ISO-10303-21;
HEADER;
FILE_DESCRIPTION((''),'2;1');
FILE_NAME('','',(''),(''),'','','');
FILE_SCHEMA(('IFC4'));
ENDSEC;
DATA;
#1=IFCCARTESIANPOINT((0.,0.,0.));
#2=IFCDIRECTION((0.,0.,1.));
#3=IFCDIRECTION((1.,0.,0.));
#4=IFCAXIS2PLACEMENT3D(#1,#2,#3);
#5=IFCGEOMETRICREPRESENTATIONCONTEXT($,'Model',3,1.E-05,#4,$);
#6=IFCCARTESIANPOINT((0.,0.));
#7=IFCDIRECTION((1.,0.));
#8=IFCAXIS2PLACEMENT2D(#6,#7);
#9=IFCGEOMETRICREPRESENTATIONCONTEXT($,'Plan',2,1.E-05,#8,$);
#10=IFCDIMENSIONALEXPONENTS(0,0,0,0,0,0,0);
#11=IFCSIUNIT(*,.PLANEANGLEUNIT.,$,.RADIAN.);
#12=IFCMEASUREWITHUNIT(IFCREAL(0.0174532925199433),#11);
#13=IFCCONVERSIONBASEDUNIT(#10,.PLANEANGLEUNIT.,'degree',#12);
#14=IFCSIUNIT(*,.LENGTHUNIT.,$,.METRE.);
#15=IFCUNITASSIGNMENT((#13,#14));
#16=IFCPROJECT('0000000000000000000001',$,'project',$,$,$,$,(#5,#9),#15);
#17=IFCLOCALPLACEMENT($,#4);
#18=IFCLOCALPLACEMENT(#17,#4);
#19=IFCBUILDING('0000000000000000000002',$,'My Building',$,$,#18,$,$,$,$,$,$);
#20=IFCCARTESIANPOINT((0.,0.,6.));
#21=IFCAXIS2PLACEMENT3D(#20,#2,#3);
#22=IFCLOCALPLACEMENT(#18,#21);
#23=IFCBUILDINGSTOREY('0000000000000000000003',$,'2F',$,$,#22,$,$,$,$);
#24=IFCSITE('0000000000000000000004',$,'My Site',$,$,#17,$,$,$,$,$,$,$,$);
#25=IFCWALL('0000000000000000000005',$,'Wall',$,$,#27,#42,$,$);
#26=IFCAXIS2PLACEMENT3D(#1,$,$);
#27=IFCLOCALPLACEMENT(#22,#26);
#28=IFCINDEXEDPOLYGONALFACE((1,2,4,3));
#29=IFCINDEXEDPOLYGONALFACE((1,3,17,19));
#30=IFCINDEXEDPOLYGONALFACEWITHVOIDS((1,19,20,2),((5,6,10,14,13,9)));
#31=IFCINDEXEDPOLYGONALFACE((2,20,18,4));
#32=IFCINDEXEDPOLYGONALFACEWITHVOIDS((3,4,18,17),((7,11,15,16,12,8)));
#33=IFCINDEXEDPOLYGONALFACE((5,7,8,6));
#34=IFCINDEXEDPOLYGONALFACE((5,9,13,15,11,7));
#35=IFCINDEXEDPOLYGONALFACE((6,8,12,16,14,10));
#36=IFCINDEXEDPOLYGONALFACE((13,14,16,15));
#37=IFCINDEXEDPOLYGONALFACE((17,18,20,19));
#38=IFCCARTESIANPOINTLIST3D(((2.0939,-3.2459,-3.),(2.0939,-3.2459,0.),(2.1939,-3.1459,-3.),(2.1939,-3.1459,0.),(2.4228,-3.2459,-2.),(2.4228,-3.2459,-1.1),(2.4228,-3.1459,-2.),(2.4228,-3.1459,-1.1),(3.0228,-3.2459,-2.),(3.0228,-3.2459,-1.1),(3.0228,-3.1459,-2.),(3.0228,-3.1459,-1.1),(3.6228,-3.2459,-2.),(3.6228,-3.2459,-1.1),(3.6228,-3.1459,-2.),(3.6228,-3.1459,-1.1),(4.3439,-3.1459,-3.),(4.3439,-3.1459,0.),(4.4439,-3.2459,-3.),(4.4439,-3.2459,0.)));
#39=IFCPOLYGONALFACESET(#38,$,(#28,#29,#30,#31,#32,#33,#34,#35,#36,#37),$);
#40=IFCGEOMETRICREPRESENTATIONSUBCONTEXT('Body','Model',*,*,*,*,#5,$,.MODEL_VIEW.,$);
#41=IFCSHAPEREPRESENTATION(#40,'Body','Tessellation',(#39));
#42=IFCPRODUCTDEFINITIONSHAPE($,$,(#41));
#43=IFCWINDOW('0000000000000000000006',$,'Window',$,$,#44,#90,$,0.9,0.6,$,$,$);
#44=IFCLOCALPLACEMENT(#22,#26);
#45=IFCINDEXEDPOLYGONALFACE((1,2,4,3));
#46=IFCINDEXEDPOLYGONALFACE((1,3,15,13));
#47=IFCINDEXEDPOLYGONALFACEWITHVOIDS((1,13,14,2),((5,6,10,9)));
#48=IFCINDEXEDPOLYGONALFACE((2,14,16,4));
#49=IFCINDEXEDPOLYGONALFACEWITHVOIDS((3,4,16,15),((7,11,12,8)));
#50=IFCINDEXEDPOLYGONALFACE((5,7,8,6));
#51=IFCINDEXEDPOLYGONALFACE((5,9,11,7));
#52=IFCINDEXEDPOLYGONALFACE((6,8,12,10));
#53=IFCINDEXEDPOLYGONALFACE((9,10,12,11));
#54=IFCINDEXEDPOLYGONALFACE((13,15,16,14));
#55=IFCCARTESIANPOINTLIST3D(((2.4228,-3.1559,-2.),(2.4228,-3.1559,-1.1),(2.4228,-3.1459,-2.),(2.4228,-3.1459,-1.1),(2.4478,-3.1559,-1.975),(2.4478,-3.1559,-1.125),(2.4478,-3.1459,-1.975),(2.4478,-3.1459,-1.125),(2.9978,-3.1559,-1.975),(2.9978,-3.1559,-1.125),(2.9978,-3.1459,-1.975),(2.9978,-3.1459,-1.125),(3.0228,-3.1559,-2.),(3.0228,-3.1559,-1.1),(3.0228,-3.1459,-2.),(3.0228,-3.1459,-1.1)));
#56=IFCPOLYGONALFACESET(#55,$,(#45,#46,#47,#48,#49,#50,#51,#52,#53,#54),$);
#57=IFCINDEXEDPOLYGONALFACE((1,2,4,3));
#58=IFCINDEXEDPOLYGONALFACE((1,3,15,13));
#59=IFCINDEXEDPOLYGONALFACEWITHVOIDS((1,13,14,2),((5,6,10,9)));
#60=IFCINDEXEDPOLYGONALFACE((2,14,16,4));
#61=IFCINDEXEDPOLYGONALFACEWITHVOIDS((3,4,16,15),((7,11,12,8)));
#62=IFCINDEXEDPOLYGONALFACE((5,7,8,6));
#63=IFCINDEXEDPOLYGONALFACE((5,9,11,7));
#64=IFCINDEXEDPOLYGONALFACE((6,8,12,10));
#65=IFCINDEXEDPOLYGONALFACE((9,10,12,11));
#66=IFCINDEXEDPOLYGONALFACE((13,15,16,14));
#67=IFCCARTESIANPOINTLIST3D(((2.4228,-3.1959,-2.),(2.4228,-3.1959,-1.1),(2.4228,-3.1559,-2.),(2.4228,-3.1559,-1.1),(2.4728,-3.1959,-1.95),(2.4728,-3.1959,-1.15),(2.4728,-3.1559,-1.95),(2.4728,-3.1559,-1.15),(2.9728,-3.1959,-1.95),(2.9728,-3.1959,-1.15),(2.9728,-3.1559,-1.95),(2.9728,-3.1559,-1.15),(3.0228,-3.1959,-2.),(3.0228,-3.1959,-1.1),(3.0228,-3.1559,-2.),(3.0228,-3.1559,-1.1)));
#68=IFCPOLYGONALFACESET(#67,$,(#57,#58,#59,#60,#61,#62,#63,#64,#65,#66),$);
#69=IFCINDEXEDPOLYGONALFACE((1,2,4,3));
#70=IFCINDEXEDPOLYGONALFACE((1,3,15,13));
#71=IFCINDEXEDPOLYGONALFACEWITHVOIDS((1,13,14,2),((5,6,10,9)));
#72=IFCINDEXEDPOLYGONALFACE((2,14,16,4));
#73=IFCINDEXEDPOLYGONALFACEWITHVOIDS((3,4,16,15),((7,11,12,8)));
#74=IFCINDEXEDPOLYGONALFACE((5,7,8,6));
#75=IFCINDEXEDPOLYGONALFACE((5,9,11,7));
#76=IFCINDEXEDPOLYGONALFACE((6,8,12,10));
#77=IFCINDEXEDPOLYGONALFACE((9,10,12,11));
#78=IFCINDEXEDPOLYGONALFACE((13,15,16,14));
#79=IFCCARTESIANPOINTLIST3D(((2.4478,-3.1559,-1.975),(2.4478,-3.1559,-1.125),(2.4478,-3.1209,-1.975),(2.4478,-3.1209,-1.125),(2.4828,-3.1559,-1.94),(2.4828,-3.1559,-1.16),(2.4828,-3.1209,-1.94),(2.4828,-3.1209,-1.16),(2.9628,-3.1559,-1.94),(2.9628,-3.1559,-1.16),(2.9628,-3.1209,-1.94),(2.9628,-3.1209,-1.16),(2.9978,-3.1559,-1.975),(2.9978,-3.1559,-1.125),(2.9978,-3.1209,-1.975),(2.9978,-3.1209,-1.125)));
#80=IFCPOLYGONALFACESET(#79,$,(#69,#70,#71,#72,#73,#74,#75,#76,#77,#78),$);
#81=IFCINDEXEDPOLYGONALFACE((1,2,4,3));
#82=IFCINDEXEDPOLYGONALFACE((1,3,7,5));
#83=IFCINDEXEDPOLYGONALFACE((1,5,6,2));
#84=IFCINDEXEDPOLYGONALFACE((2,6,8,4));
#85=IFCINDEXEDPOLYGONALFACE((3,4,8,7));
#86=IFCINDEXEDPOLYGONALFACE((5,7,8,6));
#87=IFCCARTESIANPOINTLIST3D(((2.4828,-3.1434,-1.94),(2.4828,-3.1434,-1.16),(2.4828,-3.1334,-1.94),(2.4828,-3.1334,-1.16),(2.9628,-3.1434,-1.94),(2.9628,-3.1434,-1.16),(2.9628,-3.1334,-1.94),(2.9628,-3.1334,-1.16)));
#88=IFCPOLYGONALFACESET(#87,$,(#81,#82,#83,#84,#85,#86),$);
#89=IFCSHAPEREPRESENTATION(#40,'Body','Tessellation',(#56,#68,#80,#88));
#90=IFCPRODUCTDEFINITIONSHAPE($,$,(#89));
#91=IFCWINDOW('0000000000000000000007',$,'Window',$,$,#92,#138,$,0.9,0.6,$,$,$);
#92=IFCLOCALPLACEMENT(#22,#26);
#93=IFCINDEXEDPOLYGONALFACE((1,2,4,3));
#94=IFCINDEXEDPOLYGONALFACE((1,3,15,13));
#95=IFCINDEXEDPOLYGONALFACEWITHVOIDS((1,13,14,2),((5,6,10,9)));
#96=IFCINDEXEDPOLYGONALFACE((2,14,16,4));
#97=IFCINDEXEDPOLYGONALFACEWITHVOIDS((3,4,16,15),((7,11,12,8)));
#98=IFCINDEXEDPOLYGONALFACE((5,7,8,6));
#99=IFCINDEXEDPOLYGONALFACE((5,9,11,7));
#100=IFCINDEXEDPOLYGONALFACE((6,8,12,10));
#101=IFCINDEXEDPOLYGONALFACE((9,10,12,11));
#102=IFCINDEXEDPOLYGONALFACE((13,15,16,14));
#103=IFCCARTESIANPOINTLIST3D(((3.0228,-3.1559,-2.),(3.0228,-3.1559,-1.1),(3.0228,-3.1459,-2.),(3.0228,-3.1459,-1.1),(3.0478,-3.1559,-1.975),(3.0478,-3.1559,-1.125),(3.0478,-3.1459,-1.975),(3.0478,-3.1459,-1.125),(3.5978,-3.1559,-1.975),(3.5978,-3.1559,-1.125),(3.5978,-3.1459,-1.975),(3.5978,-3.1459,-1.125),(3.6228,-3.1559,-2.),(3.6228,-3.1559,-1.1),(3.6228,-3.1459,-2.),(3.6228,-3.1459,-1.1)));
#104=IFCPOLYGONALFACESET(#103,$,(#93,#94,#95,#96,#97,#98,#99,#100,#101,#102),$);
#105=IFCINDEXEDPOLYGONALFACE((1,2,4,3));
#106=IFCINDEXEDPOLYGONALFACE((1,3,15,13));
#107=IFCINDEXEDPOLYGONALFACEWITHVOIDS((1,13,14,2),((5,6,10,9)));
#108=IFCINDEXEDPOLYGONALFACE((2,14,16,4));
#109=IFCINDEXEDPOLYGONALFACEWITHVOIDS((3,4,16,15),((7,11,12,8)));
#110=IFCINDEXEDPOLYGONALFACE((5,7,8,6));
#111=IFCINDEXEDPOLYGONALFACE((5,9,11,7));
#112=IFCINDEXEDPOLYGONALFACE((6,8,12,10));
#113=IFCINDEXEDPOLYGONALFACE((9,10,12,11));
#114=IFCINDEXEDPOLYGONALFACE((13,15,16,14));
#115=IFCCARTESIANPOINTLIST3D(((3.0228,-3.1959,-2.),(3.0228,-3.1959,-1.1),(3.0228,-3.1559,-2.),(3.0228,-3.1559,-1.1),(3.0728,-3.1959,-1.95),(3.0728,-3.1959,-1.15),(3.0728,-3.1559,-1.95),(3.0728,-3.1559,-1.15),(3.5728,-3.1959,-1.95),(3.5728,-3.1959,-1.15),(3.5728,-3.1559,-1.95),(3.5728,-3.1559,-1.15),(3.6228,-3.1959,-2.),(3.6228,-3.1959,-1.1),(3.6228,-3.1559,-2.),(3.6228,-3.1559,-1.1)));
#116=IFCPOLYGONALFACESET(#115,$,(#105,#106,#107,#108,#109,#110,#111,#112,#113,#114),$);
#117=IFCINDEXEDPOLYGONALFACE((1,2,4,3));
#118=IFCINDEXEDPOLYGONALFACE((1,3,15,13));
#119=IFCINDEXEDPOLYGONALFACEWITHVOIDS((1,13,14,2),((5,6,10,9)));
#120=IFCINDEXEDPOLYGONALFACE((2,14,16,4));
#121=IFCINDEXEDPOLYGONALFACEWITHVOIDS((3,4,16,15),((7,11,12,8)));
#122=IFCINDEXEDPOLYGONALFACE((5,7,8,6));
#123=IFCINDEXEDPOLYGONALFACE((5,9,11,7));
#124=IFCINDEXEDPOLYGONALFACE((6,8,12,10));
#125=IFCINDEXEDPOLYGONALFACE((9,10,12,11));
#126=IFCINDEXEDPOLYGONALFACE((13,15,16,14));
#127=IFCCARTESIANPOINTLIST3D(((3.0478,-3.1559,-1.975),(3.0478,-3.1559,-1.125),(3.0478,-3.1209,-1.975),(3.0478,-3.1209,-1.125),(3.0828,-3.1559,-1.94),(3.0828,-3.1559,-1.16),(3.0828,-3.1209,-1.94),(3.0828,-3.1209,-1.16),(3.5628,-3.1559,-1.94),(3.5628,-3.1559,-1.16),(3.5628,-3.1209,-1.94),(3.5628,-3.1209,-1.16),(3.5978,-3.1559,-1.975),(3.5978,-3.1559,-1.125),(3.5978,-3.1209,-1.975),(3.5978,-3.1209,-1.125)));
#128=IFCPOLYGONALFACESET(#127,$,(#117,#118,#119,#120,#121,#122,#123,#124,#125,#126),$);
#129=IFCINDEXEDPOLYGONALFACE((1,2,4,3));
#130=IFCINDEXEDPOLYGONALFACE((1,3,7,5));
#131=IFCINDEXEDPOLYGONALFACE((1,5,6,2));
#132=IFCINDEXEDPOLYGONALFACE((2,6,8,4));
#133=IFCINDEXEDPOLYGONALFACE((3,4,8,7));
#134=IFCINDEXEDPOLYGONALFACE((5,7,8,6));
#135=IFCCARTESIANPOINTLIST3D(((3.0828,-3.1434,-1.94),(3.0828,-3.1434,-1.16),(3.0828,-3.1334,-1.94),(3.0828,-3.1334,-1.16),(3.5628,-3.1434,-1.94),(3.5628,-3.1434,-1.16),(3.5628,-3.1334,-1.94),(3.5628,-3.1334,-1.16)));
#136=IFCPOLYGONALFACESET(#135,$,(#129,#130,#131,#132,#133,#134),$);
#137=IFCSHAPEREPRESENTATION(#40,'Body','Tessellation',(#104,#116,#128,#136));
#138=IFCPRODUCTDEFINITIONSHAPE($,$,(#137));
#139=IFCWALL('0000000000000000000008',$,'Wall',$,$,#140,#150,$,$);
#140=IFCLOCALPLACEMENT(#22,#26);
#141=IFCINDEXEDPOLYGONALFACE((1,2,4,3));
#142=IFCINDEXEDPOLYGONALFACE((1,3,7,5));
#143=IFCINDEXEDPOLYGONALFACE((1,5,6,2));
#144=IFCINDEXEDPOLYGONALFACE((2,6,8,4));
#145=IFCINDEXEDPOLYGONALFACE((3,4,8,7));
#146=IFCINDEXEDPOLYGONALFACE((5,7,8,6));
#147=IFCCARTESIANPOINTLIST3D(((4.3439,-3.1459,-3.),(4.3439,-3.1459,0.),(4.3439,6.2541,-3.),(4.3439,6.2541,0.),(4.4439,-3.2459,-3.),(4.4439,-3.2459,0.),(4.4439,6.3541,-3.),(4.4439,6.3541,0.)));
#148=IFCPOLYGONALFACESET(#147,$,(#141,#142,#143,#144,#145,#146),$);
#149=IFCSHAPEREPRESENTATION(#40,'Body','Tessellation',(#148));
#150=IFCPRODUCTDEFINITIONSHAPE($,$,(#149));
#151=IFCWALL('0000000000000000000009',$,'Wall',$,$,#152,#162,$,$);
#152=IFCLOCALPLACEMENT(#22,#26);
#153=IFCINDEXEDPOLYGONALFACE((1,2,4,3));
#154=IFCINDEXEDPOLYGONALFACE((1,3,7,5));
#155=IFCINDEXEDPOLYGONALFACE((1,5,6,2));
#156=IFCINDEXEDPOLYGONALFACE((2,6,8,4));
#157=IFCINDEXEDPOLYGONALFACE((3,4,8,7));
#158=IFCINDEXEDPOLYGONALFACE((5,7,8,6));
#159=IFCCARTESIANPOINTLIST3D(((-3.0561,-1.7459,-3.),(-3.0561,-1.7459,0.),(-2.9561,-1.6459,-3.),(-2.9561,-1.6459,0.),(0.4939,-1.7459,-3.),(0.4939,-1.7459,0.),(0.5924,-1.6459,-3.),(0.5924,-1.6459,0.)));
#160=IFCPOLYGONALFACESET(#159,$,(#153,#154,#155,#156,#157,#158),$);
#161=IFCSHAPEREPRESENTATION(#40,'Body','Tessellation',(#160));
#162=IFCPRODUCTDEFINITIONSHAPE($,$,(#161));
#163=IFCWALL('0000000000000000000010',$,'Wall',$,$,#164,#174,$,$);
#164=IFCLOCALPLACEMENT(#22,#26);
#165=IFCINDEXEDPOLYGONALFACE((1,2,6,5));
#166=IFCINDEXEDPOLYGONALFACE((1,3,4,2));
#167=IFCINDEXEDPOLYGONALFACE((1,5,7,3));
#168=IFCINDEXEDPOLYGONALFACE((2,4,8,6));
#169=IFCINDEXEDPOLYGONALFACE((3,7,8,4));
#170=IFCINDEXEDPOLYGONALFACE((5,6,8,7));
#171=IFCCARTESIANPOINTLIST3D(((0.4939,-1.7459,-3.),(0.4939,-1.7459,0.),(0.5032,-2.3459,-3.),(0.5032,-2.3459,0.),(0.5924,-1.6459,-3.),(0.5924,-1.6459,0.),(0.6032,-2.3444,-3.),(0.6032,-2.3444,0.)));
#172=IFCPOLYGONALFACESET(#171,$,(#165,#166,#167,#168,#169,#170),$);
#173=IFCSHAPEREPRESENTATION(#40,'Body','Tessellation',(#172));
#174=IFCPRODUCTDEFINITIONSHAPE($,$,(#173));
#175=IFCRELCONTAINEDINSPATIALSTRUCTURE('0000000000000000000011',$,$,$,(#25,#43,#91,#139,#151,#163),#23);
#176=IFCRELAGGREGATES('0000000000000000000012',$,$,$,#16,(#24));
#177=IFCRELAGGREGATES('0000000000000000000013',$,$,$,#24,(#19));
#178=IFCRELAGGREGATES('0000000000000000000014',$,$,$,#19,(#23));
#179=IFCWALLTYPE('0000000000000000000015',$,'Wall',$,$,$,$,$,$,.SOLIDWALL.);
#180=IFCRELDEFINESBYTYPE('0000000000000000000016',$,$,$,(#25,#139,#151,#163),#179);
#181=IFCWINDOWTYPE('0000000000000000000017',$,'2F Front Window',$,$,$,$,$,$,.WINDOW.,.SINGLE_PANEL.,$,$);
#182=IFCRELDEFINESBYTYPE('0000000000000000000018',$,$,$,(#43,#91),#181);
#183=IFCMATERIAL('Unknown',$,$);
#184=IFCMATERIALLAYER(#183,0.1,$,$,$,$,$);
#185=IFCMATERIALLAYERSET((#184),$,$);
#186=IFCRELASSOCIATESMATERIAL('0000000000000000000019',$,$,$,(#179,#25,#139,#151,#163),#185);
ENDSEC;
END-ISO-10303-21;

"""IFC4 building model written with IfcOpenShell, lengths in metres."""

from ifc_helpers import new_model, entity, si_unit, converted_unit, frame, origin_with_axes, origin_2d_with_axis, place, context, subcontext, project, spatial, line, indexed_curve, outline, extrude, shape, source, transform, mapped, material, layer, layer_set, layer_usage, type_object, type_shapes, element, fill, save


model = new_model("IFC4")

# Units and contexts
model_context = context("Model", 3, precision=1e-05, world=origin_with_axes())
plan_context = context("Plan", 2, precision=1e-05, world=origin_2d_with_axis())
body_context_1 = subcontext(model_context, "Body", "Model", "MODEL_VIEW")
body_context_2 = subcontext(plan_context, "Body", "Plan", "PLAN_VIEW")
ifc_project = project(units=[converted_unit("PLANEANGLEUNIT", "degree", entity("IfcReal", 0.0174532925199433), si_unit("PLANEANGLEUNIT", "RADIAN"), dimensions=[0, 0, 0, 0, 0, 0, 0]), si_unit("LENGTHUNIT", "METRE")], contexts=[model_context, plan_context])

# Site, building, storey
site_placement = place(None, origin_with_axes())
site = spatial("IfcSite", under=ifc_project, at=site_placement, Name="My Site")
building_placement = place(site_placement, origin_with_axes())
building = spatial("IfcBuilding", under=site, at=building_placement, Name="My Building")
storey_placement = place(building_placement, frame((0.0, 0.0, 6.0), z_axis=(0.0, 0.0, 1.0), x_axis=(1.0, 0.0, 0.0)))
storey = spatial("IfcBuildingStorey", under=building, at=storey_placement, Name="2F")

# Shared definitions
ifc_material = material(Name="Unknown")

# Shared definitions
ifc_layer_1 = layer(ifc_material, 0.1)
ifc_layer_set_1 = layer_set([ifc_layer_1])
wall_type = type_object("IfcWallType", Name="Wall", PredefinedType="SOLIDWALL", material=ifc_layer_set_1)

# Wall, openings, windows
ifc_layer_usage_1 = layer_usage(ifc_layer_set_1, "AXIS2", "POSITIVE", 0.0)
wall_1_placement = place(storey_placement, frame((2.0939, -3.2459, -3.0), z_axis=(0.0, 0.0, 1.0), x_axis=(1.0, 0.0, 0.0)))
wall_1 = element("IfcWall", 1, at=wall_1_placement, inside=storey, type_object=wall_type, material=ifc_layer_usage_1, Name="Wall", context=body_context_1, shape_type="SweptSolid", body=[
    extrude(outline(indexed_curve([(0.0, 0.0), (0.1, 0.1), (2.25, 0.1), (2.35, 0.0)], segments=[line(1, 2, 3, 4, 1)])), origin_with_axes(), (0.0, 0.0, 1.0), 3.0),
])
shared_shape_1 = source(origin_with_axes(), body_context_1, "Body", "SweptSolid", [
    extrude(outline(indexed_curve([(0.0, 0.0), (0.6, 0.0), (0.6, 0.9), (0.0, 0.9)], segments=[line(1, 2, 3, 4, 1)])), frame((0.0, -0.6, 0.0), z_axis=(0.0, -1.0, 0.0), x_axis=(1.0, 0.0, 0.0)), (0.0, 0.0, -1.0), 1.2),
])
opening_1_placement = place(wall_1_placement, frame((0.3289, 0.0, 1.0), z_axis=(0.0, 0.0, 1.0), x_axis=(1.0, 0.0, 0.0)))
opening_1 = element("IfcOpeningElement", 2, at=opening_1_placement, cuts=wall_1, PredefinedType="OPENING", context=body_context_1, shape_type="MappedRepresentation", body=[
    mapped(shared_shape_1, transform((0.0, 0.0, 0.0), x_axis=(1.0, 0.0, 0.0), y_axis=(0.0, 1.0, 0.0), z_axis=(0.0, 0.0, 1.0), scale=1.0)),
])
opening_2_placement = place(wall_1_placement, frame((0.9289, 0.0, 1.0), z_axis=(0.0, 0.0, 1.0), x_axis=(1.0, 0.0, 0.0)))
opening_2 = element("IfcOpeningElement", 3, at=opening_2_placement, cuts=wall_1, PredefinedType="OPENING", context=body_context_1, shape_type="MappedRepresentation", body=[
    mapped(shared_shape_1, transform((0.0, 0.0, 0.0), x_axis=(1.0, 0.0, 0.0), y_axis=(0.0, 1.0, 0.0), z_axis=(0.0, 0.0, 1.0), scale=1.0)),
])
window_type_1 = type_object("IfcWindowType", Name="2F Front Window", PartitioningType="SINGLE_PANEL", PredefinedType="WINDOW")
shared_shape_2 = source(origin_with_axes(), body_context_1, "Body", "SweptSolid", [
    extrude(outline(indexed_curve([(0.0, 0.0), (0.6, 0.0), (0.6, 0.9), (0.0, 0.9)], segments=[line(1, 2, 3, 4, 1)]), holes=[indexed_curve([(0.025, 0.025), (0.575, 0.025), (0.575, 0.875), (0.025, 0.875)], segments=[line(1, 2, 3, 4, 1)])]), frame((0.0, 0.09, 0.0), z_axis=(0.0, -1.0, 0.0), x_axis=(1.0, 0.0, 0.0)), (0.0, 0.0, -1.0), 0.01),
    extrude(outline(indexed_curve([(0.0, 0.0), (0.6, 0.0), (0.6, 0.9), (0.0, 0.9)], segments=[line(1, 2, 3, 4, 1)]), holes=[indexed_curve([(0.05, 0.05), (0.55, 0.05), (0.55, 0.85), (0.05, 0.85)], segments=[line(1, 2, 3, 4, 1)])]), frame((0.0, 0.05, 0.0), z_axis=(0.0, -1.0, 0.0), x_axis=(1.0, 0.0, 0.0)), (0.0, 0.0, -1.0), 0.04),
    extrude(outline(indexed_curve([(0.0, 0.0), (0.55, 0.0), (0.55, 0.85), (0.0, 0.85)], segments=[line(1, 2, 3, 4, 1)]), holes=[indexed_curve([(0.035, 0.035), (0.515, 0.035), (0.515, 0.815), (0.035, 0.815)], segments=[line(1, 2, 3, 4, 1)])]), frame((0.025, 0.09, 0.025), z_axis=(0.0, -1.0, 0.0), x_axis=(1.0, 0.0, 0.0)), (0.0, 0.0, -1.0), 0.035),
    extrude(outline(indexed_curve([(0.035, 0.035), (0.515, 0.035), (0.515, 0.815), (0.035, 0.815)], segments=[line(1, 2, 3, 4, 1)])), frame((0.025, 0.1025, 0.025), z_axis=(0.0, -1.0, 0.0), x_axis=(1.0, 0.0, 0.0)), (0.0, 0.0, -1.0), 0.01),
])
shared_shape_3 = source(origin_with_axes(), body_context_2, "Body", "Curve2D", [
    entity("IfcIndexedPolyCurve", entity("IfcCartesianPointList2D", [[0.05, 0.05], [0.55, 0.05]])),
    entity("IfcIndexedPolyCurve", entity("IfcCartesianPointList2D", [[0.0, 0.1], [0.025, 0.1], [0.025, 0.09], [0.05, 0.09], [0.05, 0.05], [0.0, 0.05]]), [entity("IfcLineIndex", [1, 2, 3, 4, 5, 6, 1])]),
    entity("IfcIndexedPolyCurve", entity("IfcCartesianPointList2D", [[0.6, 0.1], [0.575, 0.1], [0.575, 0.09], [0.55, 0.09], [0.55, 0.05], [0.6, 0.05]]), [entity("IfcLineIndex", [1, 2, 3, 4, 5, 6, 1])]),
    entity("IfcIndexedPolyCurve", entity("IfcCartesianPointList2D", [[0.025, 0.09], [0.06, 0.09], [0.06, 0.125], [0.025, 0.125]]), [entity("IfcLineIndex", [1, 2, 3, 4, 1])]),
    entity("IfcIndexedPolyCurve", entity("IfcCartesianPointList2D", [[0.575, 0.09], [0.54, 0.09], [0.54, 0.125], [0.575, 0.125]]), [entity("IfcLineIndex", [1, 2, 3, 4, 1])]),
    entity("IfcIndexedPolyCurve", entity("IfcCartesianPointList2D", [[0.06, 0.09], [0.54, 0.09]])),
    entity("IfcIndexedPolyCurve", entity("IfcCartesianPointList2D", [[0.06, 0.125], [0.54, 0.125]])),
    entity("IfcIndexedPolyCurve", entity("IfcCartesianPointList2D", [[0.06, 0.1075], [0.54, 0.1075]])),
])
type_shapes(window_type_1, [shared_shape_2, shared_shape_3])
window_1_placement = place(opening_1_placement, origin_with_axes())
window_1 = element("IfcWindow", 4, at=window_1_placement, inside=storey, type_object=window_type_1, Name="Window", OverallHeight=0.9, OverallWidth=0.6, shapes=[
    shape(body_context_1, "Body", "MappedRepresentation", [mapped(shared_shape_2, transform((0.0, 0.0, 0.0), x_axis=(1.0, 0.0, 0.0), y_axis=(0.0, 1.0, 0.0), z_axis=(0.0, 0.0, 1.0), scale=1.0))]),
    shape(body_context_2, "Body", "MappedRepresentation", [mapped(shared_shape_3, transform((0.0, 0.0, 0.0), x_axis=(1.0, 0.0, 0.0), y_axis=(0.0, 1.0, 0.0), z_axis=(0.0, 0.0, 1.0), scale=1.0))]),
])
fill(opening_1, window_1)
window_2_placement = place(opening_2_placement, origin_with_axes())
window_2 = element("IfcWindow", 5, at=window_2_placement, inside=storey, type_object=window_type_1, Name="Window", OverallHeight=0.9, OverallWidth=0.6, shapes=[
    shape(body_context_1, "Body", "MappedRepresentation", [mapped(shared_shape_2, transform((0.0, 0.0, 0.0), x_axis=(1.0, 0.0, 0.0), y_axis=(0.0, 1.0, 0.0), z_axis=(0.0, 0.0, 1.0), scale=1.0))]),
    shape(body_context_2, "Body", "MappedRepresentation", [mapped(shared_shape_3, transform((0.0, 0.0, 0.0), x_axis=(1.0, 0.0, 0.0), y_axis=(0.0, 1.0, 0.0), z_axis=(0.0, 0.0, 1.0), scale=1.0))]),
])
fill(opening_2, window_2)

# Walls
ifc_layer_usage_2 = layer_usage(ifc_layer_set_1, "AXIS2", "POSITIVE", 0.0)
wall_2_placement = place(storey_placement, frame((4.4439, -3.2459, -3.0), z_axis=(0.0, 0.0, 1.0), x_axis=(0.0, 1.0, 0.0)))
element("IfcWall", 6, at=wall_2_placement, inside=storey, type_object=wall_type, material=ifc_layer_usage_2, Name="Wall", context=body_context_1, shape_type="SweptSolid", body=[
    extrude(outline(indexed_curve([(0.0, 0.0), (0.1, 0.1), (9.5, 0.1), (9.6, 0.0)], segments=[line(1, 2, 3, 4, 1)])), origin_with_axes(), (0.0, 0.0, 1.0), 3.0),
])
ifc_layer_usage_3 = layer_usage(ifc_layer_set_1, "AXIS2", "POSITIVE", 0.0)
wall_3_placement = place(storey_placement, frame((-3.0561, -1.7459, -3.0), z_axis=(0.0, 0.0, 1.0), x_axis=(1.0, 0.0, 0.0)))
element("IfcWall", 7, at=wall_3_placement, inside=storey, type_object=wall_type, material=ifc_layer_usage_3, Name="Wall", context=body_context_1, shape_type="SweptSolid", body=[
    extrude(outline(indexed_curve([(0.0, 0.0), (0.1, 0.1), (3.6485, 0.1), (3.55, 0.0)], segments=[line(1, 2, 3, 4, 1)])), origin_with_axes(), (0.0, 0.0, 1.0), 3.0),
])
ifc_layer_usage_4 = layer_usage(ifc_layer_set_1, "AXIS2", "POSITIVE", 0.0)
wall_4_placement = place(storey_placement, frame((0.4939, -1.7459, -3.0), z_axis=(0.0, 0.0, 1.0), x_axis=(0.015502, -0.99988, 0.0)))
element("IfcWall", 8, at=wall_4_placement, inside=storey, type_object=wall_type, material=ifc_layer_usage_4, Name="Wall", context=body_context_1, shape_type="SweptSolid", body=[
    extrude(outline(indexed_curve([(0.0, 0.0), (-0.0985, 0.1), (0.6001, 0.1), (0.6001, 0.0)], segments=[line(1, 2, 3, 4, 1)])), origin_with_axes(), (0.0, 0.0, 1.0), 3.0),
])

save(model, "model.ifc")
